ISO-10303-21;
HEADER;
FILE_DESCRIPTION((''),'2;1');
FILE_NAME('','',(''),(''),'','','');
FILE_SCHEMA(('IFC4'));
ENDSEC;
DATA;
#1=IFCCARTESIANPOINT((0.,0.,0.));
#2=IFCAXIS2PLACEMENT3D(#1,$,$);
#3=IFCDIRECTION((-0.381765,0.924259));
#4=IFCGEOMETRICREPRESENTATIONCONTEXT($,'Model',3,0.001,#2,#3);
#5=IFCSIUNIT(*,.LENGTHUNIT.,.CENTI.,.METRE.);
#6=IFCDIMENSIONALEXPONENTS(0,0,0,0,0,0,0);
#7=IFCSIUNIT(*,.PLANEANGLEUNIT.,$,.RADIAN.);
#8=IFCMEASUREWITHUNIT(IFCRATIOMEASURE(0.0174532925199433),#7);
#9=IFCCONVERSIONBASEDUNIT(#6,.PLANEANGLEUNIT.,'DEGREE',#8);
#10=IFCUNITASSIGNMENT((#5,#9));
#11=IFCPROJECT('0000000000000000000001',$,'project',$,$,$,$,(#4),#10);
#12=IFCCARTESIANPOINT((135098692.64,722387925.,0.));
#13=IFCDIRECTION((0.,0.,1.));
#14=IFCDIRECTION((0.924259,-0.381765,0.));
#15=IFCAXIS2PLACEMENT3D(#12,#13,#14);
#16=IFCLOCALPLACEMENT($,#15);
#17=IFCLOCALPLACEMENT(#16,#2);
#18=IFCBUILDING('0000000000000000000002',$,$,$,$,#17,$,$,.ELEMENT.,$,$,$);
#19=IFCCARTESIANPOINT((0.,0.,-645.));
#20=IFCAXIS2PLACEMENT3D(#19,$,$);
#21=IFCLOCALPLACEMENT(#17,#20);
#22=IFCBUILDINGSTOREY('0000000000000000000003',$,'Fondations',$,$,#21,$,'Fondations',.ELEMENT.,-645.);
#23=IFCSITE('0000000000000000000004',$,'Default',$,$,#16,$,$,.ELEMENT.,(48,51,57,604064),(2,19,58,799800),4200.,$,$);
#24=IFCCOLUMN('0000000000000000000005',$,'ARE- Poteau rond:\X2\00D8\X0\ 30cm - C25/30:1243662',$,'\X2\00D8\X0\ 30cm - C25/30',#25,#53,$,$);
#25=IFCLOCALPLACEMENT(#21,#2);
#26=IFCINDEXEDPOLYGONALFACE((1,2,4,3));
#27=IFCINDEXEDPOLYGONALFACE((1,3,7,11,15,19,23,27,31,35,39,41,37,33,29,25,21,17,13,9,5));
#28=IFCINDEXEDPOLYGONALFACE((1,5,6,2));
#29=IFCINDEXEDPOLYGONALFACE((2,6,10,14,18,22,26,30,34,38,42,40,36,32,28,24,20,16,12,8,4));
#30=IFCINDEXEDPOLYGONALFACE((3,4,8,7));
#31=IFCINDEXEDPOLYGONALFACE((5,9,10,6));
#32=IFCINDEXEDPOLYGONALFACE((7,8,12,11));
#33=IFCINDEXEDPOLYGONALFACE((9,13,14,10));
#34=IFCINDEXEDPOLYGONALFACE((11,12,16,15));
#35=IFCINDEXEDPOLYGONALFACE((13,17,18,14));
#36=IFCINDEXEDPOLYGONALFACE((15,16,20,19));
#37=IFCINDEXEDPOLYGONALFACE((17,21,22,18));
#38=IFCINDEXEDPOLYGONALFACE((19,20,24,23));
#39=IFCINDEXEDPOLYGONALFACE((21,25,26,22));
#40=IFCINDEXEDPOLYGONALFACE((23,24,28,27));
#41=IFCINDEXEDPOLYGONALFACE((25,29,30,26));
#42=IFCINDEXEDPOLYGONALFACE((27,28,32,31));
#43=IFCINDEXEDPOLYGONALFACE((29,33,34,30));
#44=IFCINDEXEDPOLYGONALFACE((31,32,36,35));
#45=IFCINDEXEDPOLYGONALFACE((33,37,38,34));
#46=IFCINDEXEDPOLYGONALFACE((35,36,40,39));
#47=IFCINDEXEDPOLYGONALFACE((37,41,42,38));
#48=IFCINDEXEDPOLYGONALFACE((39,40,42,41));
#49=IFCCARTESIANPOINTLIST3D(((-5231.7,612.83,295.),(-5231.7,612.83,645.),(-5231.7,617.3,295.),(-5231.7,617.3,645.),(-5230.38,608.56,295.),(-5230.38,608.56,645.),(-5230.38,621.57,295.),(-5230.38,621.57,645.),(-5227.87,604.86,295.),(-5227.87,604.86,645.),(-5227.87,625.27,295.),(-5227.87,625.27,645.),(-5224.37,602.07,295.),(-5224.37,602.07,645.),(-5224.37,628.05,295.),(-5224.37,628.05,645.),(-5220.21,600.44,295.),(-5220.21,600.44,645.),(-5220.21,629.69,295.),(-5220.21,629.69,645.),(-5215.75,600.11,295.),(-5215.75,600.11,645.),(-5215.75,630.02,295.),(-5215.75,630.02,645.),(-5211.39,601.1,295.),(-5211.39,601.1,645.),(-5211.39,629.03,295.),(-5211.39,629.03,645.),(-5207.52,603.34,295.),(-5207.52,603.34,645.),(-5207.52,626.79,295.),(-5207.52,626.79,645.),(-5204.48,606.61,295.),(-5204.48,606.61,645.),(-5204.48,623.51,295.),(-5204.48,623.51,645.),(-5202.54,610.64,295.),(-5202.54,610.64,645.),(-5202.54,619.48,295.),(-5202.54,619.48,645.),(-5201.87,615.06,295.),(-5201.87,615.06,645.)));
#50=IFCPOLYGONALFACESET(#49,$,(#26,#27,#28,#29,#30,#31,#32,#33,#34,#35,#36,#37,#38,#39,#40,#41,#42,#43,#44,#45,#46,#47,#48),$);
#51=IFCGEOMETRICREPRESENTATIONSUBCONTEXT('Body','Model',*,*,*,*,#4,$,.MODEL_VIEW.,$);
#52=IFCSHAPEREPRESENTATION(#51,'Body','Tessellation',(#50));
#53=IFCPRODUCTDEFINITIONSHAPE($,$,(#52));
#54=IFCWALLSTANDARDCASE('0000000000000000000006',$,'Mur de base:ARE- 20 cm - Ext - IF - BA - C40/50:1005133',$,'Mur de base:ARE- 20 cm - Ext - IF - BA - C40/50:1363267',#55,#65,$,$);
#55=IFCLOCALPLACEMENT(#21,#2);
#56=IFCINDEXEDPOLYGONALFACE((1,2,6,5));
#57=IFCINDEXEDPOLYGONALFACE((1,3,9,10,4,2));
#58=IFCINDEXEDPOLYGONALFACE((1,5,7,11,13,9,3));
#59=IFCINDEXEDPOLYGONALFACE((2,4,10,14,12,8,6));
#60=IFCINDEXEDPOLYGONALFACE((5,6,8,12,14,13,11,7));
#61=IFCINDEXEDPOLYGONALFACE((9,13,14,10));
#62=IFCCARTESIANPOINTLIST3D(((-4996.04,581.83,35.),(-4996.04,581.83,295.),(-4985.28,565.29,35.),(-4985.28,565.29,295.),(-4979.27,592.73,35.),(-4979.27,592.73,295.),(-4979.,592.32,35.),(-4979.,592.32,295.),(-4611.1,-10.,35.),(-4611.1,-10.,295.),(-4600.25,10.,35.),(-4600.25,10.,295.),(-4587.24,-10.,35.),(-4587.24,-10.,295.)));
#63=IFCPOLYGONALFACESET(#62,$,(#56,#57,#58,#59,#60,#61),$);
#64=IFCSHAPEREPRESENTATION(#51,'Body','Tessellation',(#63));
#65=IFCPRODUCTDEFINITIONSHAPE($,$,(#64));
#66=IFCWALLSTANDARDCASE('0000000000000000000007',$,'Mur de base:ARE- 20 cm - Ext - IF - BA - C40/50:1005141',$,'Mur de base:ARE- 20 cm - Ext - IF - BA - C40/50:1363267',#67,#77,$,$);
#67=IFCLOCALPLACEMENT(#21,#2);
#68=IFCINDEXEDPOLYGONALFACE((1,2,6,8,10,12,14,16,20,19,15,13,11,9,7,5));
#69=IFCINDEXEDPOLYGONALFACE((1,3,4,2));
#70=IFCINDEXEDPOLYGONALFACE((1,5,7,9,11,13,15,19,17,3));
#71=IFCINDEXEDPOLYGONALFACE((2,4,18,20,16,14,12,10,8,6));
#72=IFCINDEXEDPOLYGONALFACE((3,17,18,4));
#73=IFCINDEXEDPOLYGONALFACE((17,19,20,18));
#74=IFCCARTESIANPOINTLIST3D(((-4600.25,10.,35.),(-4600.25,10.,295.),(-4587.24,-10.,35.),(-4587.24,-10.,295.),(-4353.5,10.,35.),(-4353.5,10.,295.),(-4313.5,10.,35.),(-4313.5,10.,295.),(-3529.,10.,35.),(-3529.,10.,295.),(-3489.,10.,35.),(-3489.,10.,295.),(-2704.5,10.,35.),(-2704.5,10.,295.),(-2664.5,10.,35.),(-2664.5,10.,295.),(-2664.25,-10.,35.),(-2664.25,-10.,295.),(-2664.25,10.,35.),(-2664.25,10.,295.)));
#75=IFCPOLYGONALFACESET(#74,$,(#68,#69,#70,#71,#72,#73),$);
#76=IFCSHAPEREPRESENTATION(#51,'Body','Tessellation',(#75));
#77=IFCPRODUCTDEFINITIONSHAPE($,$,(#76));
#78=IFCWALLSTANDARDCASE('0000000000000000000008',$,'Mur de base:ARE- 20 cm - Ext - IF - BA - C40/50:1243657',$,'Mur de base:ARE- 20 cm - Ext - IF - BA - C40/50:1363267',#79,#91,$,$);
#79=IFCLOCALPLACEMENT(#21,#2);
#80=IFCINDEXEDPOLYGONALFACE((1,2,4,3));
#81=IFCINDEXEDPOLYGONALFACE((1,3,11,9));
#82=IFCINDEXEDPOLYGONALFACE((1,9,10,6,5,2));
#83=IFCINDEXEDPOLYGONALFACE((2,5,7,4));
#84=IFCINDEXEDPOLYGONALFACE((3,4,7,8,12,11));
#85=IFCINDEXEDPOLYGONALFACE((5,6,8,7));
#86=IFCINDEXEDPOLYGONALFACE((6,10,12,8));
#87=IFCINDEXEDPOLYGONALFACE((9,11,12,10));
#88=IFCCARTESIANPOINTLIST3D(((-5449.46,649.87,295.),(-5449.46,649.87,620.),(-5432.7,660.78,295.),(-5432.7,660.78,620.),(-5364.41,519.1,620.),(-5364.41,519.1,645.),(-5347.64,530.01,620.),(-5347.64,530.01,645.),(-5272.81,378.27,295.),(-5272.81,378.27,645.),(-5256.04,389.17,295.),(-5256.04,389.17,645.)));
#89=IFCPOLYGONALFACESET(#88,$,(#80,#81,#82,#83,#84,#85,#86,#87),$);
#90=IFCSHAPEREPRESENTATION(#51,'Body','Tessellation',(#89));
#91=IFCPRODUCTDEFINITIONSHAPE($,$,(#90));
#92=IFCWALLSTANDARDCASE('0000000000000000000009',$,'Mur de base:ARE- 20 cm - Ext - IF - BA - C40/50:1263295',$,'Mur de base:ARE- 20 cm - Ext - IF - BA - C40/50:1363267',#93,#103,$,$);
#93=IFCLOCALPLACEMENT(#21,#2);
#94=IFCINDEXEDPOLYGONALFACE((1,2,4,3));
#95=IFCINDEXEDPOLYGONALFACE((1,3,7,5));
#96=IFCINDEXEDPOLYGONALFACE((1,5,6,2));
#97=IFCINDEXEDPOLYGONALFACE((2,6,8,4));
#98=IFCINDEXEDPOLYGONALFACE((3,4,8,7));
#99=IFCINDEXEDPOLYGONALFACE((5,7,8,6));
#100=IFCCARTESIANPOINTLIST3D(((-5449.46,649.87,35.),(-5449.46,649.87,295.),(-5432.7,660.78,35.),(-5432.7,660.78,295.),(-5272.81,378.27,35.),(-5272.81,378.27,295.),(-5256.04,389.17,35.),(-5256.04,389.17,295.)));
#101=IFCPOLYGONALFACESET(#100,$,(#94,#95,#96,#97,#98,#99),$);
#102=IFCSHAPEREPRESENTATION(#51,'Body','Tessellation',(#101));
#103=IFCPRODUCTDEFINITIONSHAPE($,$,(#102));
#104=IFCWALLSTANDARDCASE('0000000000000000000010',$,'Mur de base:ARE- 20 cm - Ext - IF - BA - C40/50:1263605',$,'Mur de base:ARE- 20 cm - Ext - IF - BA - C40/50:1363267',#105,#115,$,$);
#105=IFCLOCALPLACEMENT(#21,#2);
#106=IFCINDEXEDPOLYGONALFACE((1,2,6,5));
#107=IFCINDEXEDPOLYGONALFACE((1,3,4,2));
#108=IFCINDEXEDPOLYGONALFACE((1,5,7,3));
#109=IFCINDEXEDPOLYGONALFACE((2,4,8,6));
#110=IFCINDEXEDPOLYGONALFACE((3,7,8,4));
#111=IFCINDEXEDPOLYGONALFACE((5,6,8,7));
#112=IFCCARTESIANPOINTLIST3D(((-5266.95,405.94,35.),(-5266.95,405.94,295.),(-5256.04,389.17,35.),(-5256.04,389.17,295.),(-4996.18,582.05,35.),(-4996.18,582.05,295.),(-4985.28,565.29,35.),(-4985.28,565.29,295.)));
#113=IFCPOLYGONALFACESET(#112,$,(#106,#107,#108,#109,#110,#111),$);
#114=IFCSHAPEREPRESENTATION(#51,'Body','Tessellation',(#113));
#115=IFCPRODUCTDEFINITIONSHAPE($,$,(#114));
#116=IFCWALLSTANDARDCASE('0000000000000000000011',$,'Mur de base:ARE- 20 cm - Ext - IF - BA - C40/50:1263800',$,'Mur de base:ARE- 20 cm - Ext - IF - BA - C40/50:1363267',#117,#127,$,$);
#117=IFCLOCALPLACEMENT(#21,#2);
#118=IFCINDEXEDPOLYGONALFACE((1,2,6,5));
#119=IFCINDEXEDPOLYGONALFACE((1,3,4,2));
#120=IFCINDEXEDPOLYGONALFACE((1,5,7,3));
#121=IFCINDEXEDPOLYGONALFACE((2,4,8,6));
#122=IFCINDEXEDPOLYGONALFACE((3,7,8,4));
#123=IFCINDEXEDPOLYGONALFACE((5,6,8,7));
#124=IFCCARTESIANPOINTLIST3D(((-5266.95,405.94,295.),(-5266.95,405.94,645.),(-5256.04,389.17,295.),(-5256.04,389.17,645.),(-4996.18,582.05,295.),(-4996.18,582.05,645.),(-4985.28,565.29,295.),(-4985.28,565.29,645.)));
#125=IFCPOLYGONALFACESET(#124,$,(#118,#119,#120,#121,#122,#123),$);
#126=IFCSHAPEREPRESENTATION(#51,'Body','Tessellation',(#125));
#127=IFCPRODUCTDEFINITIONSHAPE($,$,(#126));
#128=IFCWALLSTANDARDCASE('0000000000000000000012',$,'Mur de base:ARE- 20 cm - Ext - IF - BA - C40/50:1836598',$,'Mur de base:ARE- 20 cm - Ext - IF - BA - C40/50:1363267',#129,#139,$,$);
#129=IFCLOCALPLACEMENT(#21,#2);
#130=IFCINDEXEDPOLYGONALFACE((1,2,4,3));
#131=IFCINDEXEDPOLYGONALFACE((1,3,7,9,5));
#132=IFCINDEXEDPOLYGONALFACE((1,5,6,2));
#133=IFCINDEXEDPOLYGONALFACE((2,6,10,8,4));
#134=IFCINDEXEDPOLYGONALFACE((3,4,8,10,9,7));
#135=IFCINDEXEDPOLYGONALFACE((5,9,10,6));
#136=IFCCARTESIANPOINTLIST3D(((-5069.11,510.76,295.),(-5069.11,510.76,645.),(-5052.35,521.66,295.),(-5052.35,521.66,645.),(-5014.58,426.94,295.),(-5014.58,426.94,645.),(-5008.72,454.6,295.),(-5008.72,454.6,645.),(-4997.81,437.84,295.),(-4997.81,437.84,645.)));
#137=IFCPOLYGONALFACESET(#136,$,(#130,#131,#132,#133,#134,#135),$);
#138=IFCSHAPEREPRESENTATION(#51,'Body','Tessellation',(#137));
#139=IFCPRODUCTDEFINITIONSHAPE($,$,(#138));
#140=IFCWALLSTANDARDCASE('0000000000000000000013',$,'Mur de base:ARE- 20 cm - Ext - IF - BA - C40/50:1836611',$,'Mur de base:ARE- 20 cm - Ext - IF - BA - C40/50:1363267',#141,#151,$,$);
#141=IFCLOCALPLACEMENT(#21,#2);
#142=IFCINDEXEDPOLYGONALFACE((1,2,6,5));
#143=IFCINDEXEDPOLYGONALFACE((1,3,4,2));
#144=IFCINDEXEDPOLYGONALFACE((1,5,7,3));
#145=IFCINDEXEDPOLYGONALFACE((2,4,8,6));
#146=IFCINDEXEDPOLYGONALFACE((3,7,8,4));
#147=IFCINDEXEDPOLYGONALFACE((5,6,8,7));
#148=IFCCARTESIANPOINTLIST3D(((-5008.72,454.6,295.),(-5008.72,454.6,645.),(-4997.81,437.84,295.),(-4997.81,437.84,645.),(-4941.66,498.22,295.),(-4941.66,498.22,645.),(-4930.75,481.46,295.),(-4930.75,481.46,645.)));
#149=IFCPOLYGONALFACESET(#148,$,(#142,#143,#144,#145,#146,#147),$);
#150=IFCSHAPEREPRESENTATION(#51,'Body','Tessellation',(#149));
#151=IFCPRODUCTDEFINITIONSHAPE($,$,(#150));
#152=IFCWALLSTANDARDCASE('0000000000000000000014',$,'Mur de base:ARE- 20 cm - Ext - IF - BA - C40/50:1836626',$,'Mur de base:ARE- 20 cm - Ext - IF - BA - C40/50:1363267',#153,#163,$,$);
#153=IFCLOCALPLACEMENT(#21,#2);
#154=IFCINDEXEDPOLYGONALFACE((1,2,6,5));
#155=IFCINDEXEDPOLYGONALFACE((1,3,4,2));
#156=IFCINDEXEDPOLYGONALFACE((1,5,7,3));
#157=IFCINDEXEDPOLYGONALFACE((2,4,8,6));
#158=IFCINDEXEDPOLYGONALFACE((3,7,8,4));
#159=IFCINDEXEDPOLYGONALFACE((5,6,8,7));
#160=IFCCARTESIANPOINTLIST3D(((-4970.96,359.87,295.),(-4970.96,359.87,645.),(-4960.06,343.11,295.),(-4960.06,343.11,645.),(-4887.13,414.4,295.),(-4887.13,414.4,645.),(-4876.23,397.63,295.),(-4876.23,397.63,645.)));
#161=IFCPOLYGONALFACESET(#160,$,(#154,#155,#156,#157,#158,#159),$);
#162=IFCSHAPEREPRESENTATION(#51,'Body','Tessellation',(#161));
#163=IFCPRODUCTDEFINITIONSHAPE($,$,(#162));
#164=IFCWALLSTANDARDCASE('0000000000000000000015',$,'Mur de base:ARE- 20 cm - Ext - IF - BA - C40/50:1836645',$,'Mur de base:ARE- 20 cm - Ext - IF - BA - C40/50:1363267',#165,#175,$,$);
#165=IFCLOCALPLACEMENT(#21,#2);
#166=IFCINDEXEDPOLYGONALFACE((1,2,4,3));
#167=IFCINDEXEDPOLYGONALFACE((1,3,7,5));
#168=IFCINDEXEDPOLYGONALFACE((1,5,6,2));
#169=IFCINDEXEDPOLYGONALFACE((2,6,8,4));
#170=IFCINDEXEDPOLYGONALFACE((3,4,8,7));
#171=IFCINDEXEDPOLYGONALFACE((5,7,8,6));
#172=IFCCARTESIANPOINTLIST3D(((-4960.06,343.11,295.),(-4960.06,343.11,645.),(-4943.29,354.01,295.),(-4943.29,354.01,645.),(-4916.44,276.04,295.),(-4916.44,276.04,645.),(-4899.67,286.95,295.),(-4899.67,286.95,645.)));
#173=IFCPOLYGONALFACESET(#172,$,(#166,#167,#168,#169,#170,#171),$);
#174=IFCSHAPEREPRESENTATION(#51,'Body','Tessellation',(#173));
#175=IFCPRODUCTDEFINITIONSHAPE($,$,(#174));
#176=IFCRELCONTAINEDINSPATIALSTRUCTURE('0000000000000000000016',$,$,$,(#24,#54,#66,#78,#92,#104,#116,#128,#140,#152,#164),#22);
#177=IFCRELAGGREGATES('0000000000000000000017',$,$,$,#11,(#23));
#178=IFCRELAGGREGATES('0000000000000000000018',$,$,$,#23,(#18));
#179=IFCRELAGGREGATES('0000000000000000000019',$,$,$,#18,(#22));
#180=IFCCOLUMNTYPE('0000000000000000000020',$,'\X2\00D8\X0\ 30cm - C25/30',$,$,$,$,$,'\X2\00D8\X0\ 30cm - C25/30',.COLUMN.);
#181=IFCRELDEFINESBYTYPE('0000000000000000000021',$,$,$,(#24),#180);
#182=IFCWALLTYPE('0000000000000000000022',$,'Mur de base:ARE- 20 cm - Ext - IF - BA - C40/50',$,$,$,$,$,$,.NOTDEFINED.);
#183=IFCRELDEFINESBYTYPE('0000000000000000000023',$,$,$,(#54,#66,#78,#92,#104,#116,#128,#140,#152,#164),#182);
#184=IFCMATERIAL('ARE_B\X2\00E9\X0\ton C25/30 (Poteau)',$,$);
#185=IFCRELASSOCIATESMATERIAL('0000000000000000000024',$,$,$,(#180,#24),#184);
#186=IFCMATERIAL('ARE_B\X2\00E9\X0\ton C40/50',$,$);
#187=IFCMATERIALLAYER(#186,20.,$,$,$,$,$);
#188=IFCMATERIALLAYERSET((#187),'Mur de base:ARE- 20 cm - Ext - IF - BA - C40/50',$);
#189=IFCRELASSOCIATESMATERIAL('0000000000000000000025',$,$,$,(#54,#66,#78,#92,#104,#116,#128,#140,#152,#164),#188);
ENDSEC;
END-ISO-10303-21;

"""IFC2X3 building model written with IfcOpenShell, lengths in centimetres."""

from ifc_helpers import new_model, entity, si_unit, converted_unit, direction, frame, frame_2d, origin, place, context, subcontext, project, spatial, polyline, rectangle, circle, outline, extrude, clip, bounded_halfspace, source, transform, mapped, material, layer, layer_set, layer_usage, type_object, type_shapes, element, save


model = new_model("IFC2X3")

# Units and contexts
model_context = context("Model", 3, precision=0.001, world=origin(), true_north=direction((-0.381765, 0.924259)))
body_context = subcontext(model_context, "Body", "Model", "MODEL_VIEW")
ifc_project = project(units=[si_unit("LENGTHUNIT", "METRE", prefix="CENTI"), converted_unit("PLANEANGLEUNIT", "DEGREE", entity("IfcRatioMeasure", 0.0174532925199433), si_unit("PLANEANGLEUNIT", "RADIAN"), dimensions=[0, 0, 0, 0, 0, 0, 0])], contexts=[model_context])

# Site, building, storey
site_placement = place(None, frame((135098692.64, 722387925.0, 0.0), z_axis=(0.0, 0.0, 1.0), x_axis=(0.924259, -0.381765, 0.0)))
site = spatial("IfcSite", under=ifc_project, at=site_placement, Name="Default", CompositionType="ELEMENT", RefLatitude=(48, 51, 57, 604064), RefLongitude=(2, 19, 58, 799800), RefElevation=4200.0)
building_placement = place(site_placement, origin())
building = spatial("IfcBuilding", under=site, at=building_placement, CompositionType="ELEMENT")
storey_placement = place(building_placement, frame((0.0, 0.0, -645.0)))
storey = spatial("IfcBuildingStorey", under=building, at=storey_placement, Name="Fondations", LongName="Fondations", CompositionType="ELEMENT", Elevation=-645.0)

# Column
ifc_material_1 = material(Name="ARE_Béton C25/30 (Poteau)")
column_type = type_object("IfcColumnType", Name="Ø 30cm - C25/30", ElementType="Ø 30cm - C25/30", PredefinedType="COLUMN", material=ifc_material_1)
shared_shape_1 = source(origin(), body_context, "Body", "SweptSolid", [
    extrude(circle(Radius=15.0, at=frame_2d((0.0, 0.0), x_axis=(1.0, 0.0))), frame((0.0, 0.0, -350.0)), (0.0, 0.0, 1.0), 350.0),
])
type_shapes(column_type, [shared_shape_1])
column_placement = place(storey_placement, frame((-5216.87, 615.06, 645.0)))
element("IfcColumn", 1, at=column_placement, inside=storey, type_object=column_type, material=ifc_material_1, Name="ARE- Poteau rond:Ø 30cm - C25/30:1243662", ObjectType="Ø 30cm - C25/30", context=body_context, shape_type="MappedRepresentation", body=[
    mapped(shared_shape_1, transform((0.0, 0.0, 0.0), scale=1.0)),
])

# Walls
ifc_material_2 = material(Name="ARE_Béton C40/50")
ifc_layer_1 = layer(ifc_material_2, 20.0)
ifc_layer_set_1 = layer_set([ifc_layer_1], Name="Mur de base:ARE- 20 cm - Ext - IF - BA - C40/50")
ifc_layer_usage_1 = layer_usage(ifc_layer_set_1, "AXIS2", "NEGATIVE", 10.0)
wall_type_1 = type_object("IfcWallType", Name="Mur de base:ARE- 20 cm - Ext - IF - BA - C40/50", PredefinedType="NOTDEFINED")
wall_1_placement = place(storey_placement, frame((-4595.62, -15.45, 35.0), z_axis=(0.0, 0.0, 1.0), x_axis=(-0.545236, 0.838282, 0.0)))
element("IfcWallStandardCase", 2, at=wall_1_placement, inside=storey, type_object=wall_type_1, material=ifc_layer_usage_1, Name="Mur de base:ARE- 20 cm - Ext - IF - BA - C40/50:1005133", ObjectType="Mur de base:ARE- 20 cm - Ext - IF - BA - C40/50:1363267", context=body_context, shape_type="SweptSolid", body=[
    extrude(outline(polyline([(719.01, -10.0), (719.01, 10.0), (699.28, 10.0), (13.01, 10.0), (0.0, -10.0), (23.86, -10.0), (718.51, -10.0), (719.01, -10.0)])), origin(), (0.0, 0.0, 1.0), 260.0),
])
ifc_layer_usage_2 = layer_usage(ifc_layer_set_1, "AXIS2", "NEGATIVE", 10.0)
wall_2_placement = place(storey_placement, frame((-4600.25, 0.0, 35.0)))
element("IfcWallStandardCase", 3, at=wall_2_placement, inside=storey, type_object=wall_type_1, material=ifc_layer_usage_2, Name="Mur de base:ARE- 20 cm - Ext - IF - BA - C40/50:1005141", ObjectType="Mur de base:ARE- 20 cm - Ext - IF - BA - C40/50:1363267", context=body_context, shape_type="SweptSolid", body=[
    extrude(outline(polyline([(1936.0, -10.0), (1936.0, 10.0), (1935.75, 10.0), (1895.75, 10.0), (1111.25, 10.0), (1071.25, 10.0), (286.75, 10.0), (246.75, 10.0), (0.0, 10.0), (13.01, -10.0), (1936.0, -10.0)])), origin(), (0.0, 0.0, 1.0), 260.0),
])
ifc_layer_usage_3 = layer_usage(ifc_layer_set_1, "AXIS2", "NEGATIVE", 10.0)
wall_3_placement = place(storey_placement, frame((-5264.42, 383.72, 295.0), z_axis=(0.0, 0.0, 1.0), x_axis=(-0.545236, 0.838282, 0.0)))
element("IfcWallStandardCase", 4, at=wall_3_placement, inside=storey, type_object=wall_type_1, material=ifc_layer_usage_3, Name="Mur de base:ARE- 20 cm - Ext - IF - BA - C40/50:1243657", ObjectType="Mur de base:ARE- 20 cm - Ext - IF - BA - C40/50:1363267", context=body_context, shape_type="Clipping", body=[
    clip(clip(extrude(rectangle(XDim=324.0, YDim=20.0, at=frame_2d((162.0, 0.0), x_axis=(-1.0, 0.0))), origin(), (0.0, 0.0, 1.0), 350.0), bounded_halfspace(frame((168.0, 10.0, 325.0), z_axis=(0.0, 0.0, -1.0), x_axis=(0.0, -1.0, 0.0)), True, frame((168.0, 10.0, 325.0), z_axis=(0.0, 0.0, -1.0), x_axis=(0.0, -1.0, 0.0)), polyline([(0.0, 0.0), (0.0, -156.0), (20.0, -156.0), (20.0, 0.0), (0.0, 0.0)]))), bounded_halfspace(frame((168.0, -10.0, 325.0), z_axis=(-1.0, 0.0, 0.0), x_axis=(0.0, 0.0, 1.0)), True, frame((168.0, -10.0, 325.0), z_axis=(-1.0, 0.0, 0.0), x_axis=(0.0, 0.0, 1.0)), polyline([(0.0, 0.0), (25.0, 0.0), (25.0, 20.0), (0.0, 20.0), (0.0, 0.0)]))),
])
ifc_layer_usage_4 = layer_usage(ifc_layer_set_1, "AXIS2", "NEGATIVE", 10.0)
wall_4_placement = place(storey_placement, frame((-5264.42, 383.72, 35.0), z_axis=(0.0, 0.0, 1.0), x_axis=(-0.545236, 0.838282, 0.0)))
element("IfcWallStandardCase", 5, at=wall_4_placement, inside=storey, type_object=wall_type_1, material=ifc_layer_usage_4, Name="Mur de base:ARE- 20 cm - Ext - IF - BA - C40/50:1263295", ObjectType="Mur de base:ARE- 20 cm - Ext - IF - BA - C40/50:1363267", context=body_context, shape_type="SweptSolid", body=[
    extrude(rectangle(XDim=324.0, YDim=20.0, at=frame_2d((162.0, 0.0), x_axis=(-1.0, 0.0))), origin(), (0.0, 0.0, 1.0), 260.0),
])
ifc_layer_usage_5 = layer_usage(ifc_layer_set_1, "AXIS2", "NEGATIVE", 10.0)
wall_5_placement = place(storey_placement, frame((-5261.49, 397.56, 35.0), z_axis=(0.0, 0.0, 1.0), x_axis=(0.838282, 0.545236, 0.0)))
element("IfcWallStandardCase", 6, at=wall_5_placement, inside=storey, type_object=wall_type_1, material=ifc_layer_usage_5, Name="Mur de base:ARE- 20 cm - Ext - IF - BA - C40/50:1263605", ObjectType="Mur de base:ARE- 20 cm - Ext - IF - BA - C40/50:1363267", context=body_context, shape_type="SweptSolid", body=[
    extrude(rectangle(XDim=323.0, YDim=20.0, at=frame_2d((161.5, 0.0), x_axis=(-1.0, 0.0))), origin(), (0.0, 0.0, 1.0), 260.0),
])
ifc_layer_usage_6 = layer_usage(ifc_layer_set_1, "AXIS2", "NEGATIVE", 10.0)
wall_6_placement = place(storey_placement, frame((-5261.49, 397.56, 295.0), z_axis=(0.0, 0.0, 1.0), x_axis=(0.838282, 0.545236, 0.0)))
element("IfcWallStandardCase", 7, at=wall_6_placement, inside=storey, type_object=wall_type_1, material=ifc_layer_usage_6, Name="Mur de base:ARE- 20 cm - Ext - IF - BA - C40/50:1263800", ObjectType="Mur de base:ARE- 20 cm - Ext - IF - BA - C40/50:1363267", context=body_context, shape_type="SweptSolid", body=[
    extrude(rectangle(XDim=323.0, YDim=20.0, at=frame_2d((161.5, 0.0), x_axis=(-1.0, 0.0))), origin(), (0.0, 0.0, 1.0), 350.0),
])
ifc_layer_usage_7 = layer_usage(ifc_layer_set_1, "AXIS2", "NEGATIVE", 10.0)
wall_7_placement = place(storey_placement, frame((-5006.2, 432.39, 295.0), z_axis=(0.0, 0.0, 1.0), x_axis=(-0.54534, 0.838215, 0.0)))
element("IfcWallStandardCase", 8, at=wall_7_placement, inside=storey, type_object=wall_type_1, material=ifc_layer_usage_7, Name="Mur de base:ARE- 20 cm - Ext - IF - BA - C40/50:1836598", ObjectType="Mur de base:ARE- 20 cm - Ext - IF - BA - C40/50:1363267", context=body_context, shape_type="SweptSolid", body=[
    extrude(outline(polyline([(100.0, -10.0), (100.0, 10.0), (0.0, 10.0), (0.0, -10.0), (20.0, -10.0), (100.0, -10.0)])), origin(), (0.0, 0.0, 1.0), 350.0),
])
ifc_layer_usage_8 = layer_usage(ifc_layer_set_1, "AXIS2", "NEGATIVE", 10.0)
wall_8_placement = place(storey_placement, frame((-4936.21, 489.84, 295.0), z_axis=(0.0, 0.0, 1.0), x_axis=(-0.838282, -0.545236, 0.0)))
element("IfcWallStandardCase", 9, at=wall_8_placement, inside=storey, type_object=wall_type_1, material=ifc_layer_usage_8, Name="Mur de base:ARE- 20 cm - Ext - IF - BA - C40/50:1836611", ObjectType="Mur de base:ARE- 20 cm - Ext - IF - BA - C40/50:1363267", context=body_context, shape_type="SweptSolid", body=[
    extrude(outline(polyline([(80.0, -10.0), (80.0, 10.0), (0.0, 10.0), (0.0, -10.0), (80.0, -10.0)])), origin(), (0.0, 0.0, 1.0), 350.0),
])
ifc_layer_usage_9 = layer_usage(ifc_layer_set_1, "AXIS2", "NEGATIVE", 10.0)
wall_9_placement = place(storey_placement, frame((-4965.51, 351.49, 295.0), z_axis=(0.0, 0.0, 1.0), x_axis=(0.838282, 0.545236, 0.0)))
element("IfcWallStandardCase", 10, at=wall_9_placement, inside=storey, type_object=wall_type_1, material=ifc_layer_usage_9, Name="Mur de base:ARE- 20 cm - Ext - IF - BA - C40/50:1836626", ObjectType="Mur de base:ARE- 20 cm - Ext - IF - BA - C40/50:1363267", context=body_context, shape_type="SweptSolid", body=[
    extrude(rectangle(XDim=100.0, YDim=20.0, at=frame_2d((50.0, 0.0), x_axis=(-1.0, 0.0))), origin(), (0.0, 0.0, 1.0), 350.0),
])
ifc_layer_usage_10 = layer_usage(ifc_layer_set_1, "AXIS2", "NEGATIVE", 10.0)
wall_10_placement = place(storey_placement, frame((-4908.06, 281.5, 295.0), z_axis=(0.0, 0.0, 1.0), x_axis=(-0.545236, 0.838282, 0.0)))
element("IfcWallStandardCase", 11, at=wall_10_placement, inside=storey, type_object=wall_type_1, material=ifc_layer_usage_10, Name="Mur de base:ARE- 20 cm - Ext - IF - BA - C40/50:1836645", ObjectType="Mur de base:ARE- 20 cm - Ext - IF - BA - C40/50:1363267", context=body_context, shape_type="SweptSolid", body=[
    extrude(rectangle(XDim=80.0, YDim=20.0, at=frame_2d((40.0, 0.0), x_axis=(-1.0, 0.0))), origin(), (0.0, 0.0, 1.0), 350.0),
])

save(model, "model.ifc")
